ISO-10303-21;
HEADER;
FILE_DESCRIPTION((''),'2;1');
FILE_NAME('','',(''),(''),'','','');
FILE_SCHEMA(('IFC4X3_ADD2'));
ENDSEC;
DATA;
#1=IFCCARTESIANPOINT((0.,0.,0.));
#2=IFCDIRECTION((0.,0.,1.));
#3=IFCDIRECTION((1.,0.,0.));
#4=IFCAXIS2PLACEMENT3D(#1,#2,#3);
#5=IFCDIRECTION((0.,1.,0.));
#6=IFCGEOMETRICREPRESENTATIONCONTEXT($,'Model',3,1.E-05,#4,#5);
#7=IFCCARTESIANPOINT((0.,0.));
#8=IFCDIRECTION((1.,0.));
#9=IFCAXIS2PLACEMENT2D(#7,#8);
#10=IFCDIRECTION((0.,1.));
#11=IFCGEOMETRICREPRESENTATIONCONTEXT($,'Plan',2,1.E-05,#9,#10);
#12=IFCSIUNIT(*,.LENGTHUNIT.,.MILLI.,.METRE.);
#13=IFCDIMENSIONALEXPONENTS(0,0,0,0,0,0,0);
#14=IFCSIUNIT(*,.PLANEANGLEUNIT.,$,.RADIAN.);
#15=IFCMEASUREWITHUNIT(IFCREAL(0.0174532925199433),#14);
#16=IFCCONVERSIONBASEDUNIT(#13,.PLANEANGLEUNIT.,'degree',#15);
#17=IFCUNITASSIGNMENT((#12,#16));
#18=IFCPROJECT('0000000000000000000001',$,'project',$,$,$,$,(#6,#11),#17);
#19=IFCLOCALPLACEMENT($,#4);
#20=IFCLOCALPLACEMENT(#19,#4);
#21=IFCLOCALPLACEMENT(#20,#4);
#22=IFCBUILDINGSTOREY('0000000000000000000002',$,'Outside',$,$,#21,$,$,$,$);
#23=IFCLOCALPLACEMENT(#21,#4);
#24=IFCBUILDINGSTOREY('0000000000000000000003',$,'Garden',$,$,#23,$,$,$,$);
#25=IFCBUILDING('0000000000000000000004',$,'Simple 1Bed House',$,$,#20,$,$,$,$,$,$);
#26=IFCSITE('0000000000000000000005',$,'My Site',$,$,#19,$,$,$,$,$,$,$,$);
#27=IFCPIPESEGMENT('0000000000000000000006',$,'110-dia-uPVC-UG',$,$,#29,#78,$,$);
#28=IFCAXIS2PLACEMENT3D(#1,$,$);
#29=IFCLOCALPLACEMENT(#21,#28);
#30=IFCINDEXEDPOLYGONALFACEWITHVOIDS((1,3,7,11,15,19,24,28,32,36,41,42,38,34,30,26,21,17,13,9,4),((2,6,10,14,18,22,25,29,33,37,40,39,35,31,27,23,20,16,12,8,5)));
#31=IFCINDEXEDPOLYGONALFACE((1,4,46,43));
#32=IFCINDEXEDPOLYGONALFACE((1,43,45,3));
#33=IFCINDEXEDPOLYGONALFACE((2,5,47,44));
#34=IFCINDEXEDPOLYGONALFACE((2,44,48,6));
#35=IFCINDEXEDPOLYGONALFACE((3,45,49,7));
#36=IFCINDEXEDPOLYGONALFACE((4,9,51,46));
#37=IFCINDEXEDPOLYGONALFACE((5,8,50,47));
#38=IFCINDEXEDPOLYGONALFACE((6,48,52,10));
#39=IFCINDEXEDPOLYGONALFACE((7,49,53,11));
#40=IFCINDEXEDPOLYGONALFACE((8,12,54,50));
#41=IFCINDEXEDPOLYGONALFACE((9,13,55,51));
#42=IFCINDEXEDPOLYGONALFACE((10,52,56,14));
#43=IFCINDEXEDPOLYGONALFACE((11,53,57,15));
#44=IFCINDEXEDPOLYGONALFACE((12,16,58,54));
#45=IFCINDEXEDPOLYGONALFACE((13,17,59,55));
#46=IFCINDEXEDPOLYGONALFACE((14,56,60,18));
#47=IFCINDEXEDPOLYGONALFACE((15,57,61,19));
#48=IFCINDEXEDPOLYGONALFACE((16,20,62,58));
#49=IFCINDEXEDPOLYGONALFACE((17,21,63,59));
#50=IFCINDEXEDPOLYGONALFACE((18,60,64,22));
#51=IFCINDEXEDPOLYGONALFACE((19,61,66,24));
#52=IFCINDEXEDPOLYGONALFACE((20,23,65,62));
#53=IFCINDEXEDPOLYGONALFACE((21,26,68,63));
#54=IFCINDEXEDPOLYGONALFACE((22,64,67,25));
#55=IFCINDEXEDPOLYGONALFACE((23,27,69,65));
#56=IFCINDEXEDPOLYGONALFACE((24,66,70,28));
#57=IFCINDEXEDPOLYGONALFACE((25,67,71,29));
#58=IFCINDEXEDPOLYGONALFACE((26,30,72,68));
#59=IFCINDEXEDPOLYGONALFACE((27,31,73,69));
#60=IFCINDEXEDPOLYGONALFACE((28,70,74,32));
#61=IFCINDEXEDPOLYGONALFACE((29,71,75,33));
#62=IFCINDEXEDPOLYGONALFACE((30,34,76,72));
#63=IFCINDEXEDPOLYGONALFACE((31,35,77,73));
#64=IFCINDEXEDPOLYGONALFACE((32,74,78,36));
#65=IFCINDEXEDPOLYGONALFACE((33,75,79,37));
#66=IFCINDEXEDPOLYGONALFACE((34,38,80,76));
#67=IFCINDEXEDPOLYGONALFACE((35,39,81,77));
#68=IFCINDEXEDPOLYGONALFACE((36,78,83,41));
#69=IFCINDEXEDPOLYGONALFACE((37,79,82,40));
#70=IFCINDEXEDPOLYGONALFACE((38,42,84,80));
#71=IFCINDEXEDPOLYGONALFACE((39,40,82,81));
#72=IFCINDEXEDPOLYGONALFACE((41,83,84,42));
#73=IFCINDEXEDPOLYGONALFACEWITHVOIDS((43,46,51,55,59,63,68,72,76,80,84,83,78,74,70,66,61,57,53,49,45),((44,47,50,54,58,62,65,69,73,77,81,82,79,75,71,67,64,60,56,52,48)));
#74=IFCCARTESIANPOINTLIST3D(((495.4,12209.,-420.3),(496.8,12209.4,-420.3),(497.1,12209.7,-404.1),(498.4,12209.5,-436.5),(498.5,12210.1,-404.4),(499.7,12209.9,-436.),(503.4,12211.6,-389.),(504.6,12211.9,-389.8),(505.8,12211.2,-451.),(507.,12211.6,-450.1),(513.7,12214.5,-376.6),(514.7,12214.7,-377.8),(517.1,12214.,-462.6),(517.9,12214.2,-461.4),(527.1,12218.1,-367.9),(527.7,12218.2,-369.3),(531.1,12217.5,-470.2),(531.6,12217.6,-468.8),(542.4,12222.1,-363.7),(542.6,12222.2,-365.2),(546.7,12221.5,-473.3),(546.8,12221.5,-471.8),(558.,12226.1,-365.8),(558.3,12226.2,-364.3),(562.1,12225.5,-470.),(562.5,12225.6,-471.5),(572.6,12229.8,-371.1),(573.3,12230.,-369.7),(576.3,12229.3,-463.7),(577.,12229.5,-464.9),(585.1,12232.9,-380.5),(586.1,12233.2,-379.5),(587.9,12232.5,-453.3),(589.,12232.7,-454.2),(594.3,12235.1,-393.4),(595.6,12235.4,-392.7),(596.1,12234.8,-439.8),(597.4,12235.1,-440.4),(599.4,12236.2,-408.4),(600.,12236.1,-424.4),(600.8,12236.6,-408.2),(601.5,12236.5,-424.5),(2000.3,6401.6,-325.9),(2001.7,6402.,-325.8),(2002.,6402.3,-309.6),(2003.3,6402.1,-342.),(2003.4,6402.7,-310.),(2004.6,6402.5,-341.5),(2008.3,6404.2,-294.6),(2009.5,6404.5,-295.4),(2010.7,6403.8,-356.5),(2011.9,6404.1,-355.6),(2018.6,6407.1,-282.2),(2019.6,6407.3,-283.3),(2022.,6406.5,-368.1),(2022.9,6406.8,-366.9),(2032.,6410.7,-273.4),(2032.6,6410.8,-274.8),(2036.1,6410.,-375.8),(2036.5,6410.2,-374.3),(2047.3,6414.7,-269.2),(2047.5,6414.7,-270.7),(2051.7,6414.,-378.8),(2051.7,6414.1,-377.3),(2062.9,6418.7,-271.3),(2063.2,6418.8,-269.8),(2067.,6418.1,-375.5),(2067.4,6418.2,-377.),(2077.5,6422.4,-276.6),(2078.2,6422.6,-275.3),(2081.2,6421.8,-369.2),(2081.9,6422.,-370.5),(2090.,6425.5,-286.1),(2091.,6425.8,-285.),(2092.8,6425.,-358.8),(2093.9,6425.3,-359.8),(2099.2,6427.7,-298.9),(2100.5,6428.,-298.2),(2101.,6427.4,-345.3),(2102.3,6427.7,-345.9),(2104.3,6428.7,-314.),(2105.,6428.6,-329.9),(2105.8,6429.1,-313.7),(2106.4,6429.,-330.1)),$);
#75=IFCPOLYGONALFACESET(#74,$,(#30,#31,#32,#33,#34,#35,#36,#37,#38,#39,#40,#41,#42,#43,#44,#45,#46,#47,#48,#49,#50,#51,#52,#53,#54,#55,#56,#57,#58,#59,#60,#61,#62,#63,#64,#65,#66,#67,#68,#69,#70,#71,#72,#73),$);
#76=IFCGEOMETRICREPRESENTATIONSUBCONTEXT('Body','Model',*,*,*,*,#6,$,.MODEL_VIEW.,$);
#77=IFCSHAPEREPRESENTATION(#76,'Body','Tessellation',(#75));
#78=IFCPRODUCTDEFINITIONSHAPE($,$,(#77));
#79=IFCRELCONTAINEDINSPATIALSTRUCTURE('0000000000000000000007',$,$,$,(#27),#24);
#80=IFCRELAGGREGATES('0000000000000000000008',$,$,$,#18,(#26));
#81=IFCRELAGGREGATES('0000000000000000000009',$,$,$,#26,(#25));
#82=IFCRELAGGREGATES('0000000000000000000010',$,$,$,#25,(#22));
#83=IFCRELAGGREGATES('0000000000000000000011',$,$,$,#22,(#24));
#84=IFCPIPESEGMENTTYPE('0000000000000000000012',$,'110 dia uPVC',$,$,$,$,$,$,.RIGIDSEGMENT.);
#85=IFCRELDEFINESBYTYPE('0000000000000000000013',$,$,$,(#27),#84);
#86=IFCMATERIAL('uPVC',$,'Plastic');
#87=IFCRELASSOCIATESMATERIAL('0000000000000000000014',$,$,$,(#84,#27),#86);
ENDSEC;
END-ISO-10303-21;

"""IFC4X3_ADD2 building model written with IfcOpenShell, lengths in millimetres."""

from ifc_helpers import new_model, entity, si_unit, converted_unit, direction, frame, origin_with_axes, origin_2d_with_axis, place, context, subcontext, project, spatial, hollow_circle, extrude, material, material_profile, profile_set, profile_usage, type_object, element, save


model = new_model("IFC4X3_ADD2")

# Units and contexts
model_context = context("Model", 3, precision=1e-05, world=origin_with_axes(), true_north=direction((0.0, 1.0, 0.0)))
plan_context = context("Plan", 2, precision=1e-05, world=origin_2d_with_axis(), true_north=direction((0.0, 1.0)))
body_context = subcontext(model_context, "Body", "Model", "MODEL_VIEW")
ifc_project = project(units=[si_unit("LENGTHUNIT", "METRE", prefix="MILLI"), converted_unit("PLANEANGLEUNIT", "degree", entity("IfcReal", 0.0174532925199433), si_unit("PLANEANGLEUNIT", "RADIAN"), dimensions=[0, 0, 0, 0, 0, 0, 0])], contexts=[model_context, plan_context])

# Site, building, storeys
site_placement = place(None, origin_with_axes())
site = spatial("IfcSite", under=ifc_project, at=site_placement, Name="My Site")
building_placement = place(site_placement, origin_with_axes())
building = spatial("IfcBuilding", under=site, at=building_placement, Name="Simple 1Bed House")
storey_1_placement = place(building_placement, origin_with_axes())
storey_1 = spatial("IfcBuildingStorey", under=building, at=storey_1_placement, Name="Outside")
storey_2_placement = place(storey_1_placement, origin_with_axes())
storey_2 = spatial("IfcBuildingStorey", under=storey_1, at=storey_2_placement, Name="Garden")

# Pipe segment
ifc_material_1 = material(Name="uPVC", Category="Plastic")
ifc_material_profile = material_profile(ifc_material_1, hollow_circle(Radius=55.0, WallThickness=1.5))
ifc_profile_set = profile_set([ifc_material_profile])
pipe_segment_type = type_object("IfcPipeSegmentType", Name="110 dia uPVC", PredefinedType="RIGIDSEGMENT", material=ifc_profile_set)
ifc_profile_usage_1 = profile_usage(ifc_profile_set, cardinal=5)
pipe_segment_1_placement = place(storey_2_placement, frame((2053.5, 6415.4, -323.9), z_axis=(-0.250818, 0.967906, -0.015745), x_axis=(-0.967234, -0.251239, -0.036571)))
element("IfcPipeSegment", 1, at=pipe_segment_1_placement, inside=storey_2, type_object=pipe_segment_type, material=ifc_profile_usage_1, Name="110-dia-uPVC-UG", context=body_context, shape_type="SweptSolid", body=[
    extrude(hollow_circle(Radius=55.0, WallThickness=1.5), origin_with_axes(), (0.0, 0.0, 1.0), 6000.0),
])

save(model, "model.ifc")
